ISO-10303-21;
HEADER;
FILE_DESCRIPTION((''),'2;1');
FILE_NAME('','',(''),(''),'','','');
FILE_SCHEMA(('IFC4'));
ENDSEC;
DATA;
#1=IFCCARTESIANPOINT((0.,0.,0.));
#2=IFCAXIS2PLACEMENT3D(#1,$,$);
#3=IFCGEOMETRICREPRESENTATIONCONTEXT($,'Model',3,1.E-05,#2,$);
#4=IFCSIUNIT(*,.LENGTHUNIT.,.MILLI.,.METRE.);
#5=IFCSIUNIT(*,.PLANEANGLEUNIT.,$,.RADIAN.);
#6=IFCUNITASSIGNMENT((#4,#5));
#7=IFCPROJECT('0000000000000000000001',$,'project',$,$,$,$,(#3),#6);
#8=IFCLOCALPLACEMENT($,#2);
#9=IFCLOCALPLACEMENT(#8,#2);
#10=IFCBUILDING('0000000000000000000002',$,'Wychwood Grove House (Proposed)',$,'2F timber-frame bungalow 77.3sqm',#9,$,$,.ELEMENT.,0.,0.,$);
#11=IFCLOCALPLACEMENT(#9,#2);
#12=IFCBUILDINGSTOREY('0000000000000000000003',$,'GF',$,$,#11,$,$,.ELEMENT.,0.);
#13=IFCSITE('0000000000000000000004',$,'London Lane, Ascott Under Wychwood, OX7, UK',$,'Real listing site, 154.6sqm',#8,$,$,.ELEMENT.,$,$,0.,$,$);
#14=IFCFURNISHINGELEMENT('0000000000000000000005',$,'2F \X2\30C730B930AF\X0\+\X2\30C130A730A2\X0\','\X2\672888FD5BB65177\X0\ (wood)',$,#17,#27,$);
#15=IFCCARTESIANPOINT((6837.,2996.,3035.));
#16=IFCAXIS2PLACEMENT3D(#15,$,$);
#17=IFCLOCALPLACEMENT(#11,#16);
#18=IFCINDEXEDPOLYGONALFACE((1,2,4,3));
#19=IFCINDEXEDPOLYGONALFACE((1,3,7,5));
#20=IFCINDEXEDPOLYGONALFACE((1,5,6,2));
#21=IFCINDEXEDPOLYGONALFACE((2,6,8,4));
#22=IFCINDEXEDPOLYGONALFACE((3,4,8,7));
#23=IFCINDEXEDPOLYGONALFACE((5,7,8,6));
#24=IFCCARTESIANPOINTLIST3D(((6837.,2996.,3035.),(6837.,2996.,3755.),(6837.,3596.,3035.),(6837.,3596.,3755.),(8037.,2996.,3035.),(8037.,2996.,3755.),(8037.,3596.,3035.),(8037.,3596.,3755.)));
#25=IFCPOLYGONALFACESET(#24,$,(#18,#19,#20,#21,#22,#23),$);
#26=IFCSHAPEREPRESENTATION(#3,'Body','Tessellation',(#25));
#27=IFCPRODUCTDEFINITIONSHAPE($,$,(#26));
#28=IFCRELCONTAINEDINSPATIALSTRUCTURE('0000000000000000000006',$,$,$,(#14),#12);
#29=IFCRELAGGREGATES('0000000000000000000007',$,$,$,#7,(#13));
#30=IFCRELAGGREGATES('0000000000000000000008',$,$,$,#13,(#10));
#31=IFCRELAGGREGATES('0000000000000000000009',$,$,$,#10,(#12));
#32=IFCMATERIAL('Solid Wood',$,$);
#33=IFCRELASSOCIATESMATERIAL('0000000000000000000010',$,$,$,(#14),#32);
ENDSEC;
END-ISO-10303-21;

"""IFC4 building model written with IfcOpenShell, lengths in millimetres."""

from ifc_helpers import new_model, si_unit, frame, frame_2d, origin, place, context, project, spatial, rectangle, extrude, material, element, save


model = new_model("IFC4")

# Units and contexts
model_context = context("Model", 3, precision=1e-05, world=origin())
ifc_project = project(units=[si_unit("LENGTHUNIT", "METRE", prefix="MILLI"), si_unit("PLANEANGLEUNIT", "RADIAN")], contexts=[model_context])

# Site, building, storey
site_placement = place(None, origin())
site = spatial("IfcSite", under=ifc_project, at=site_placement, Name="London Lane, Ascott Under Wychwood, OX7, UK", ObjectType="Real listing site, 154.6sqm", CompositionType="ELEMENT", RefElevation=0.0)
building_placement = place(site_placement, origin())
building = spatial("IfcBuilding", under=site, at=building_placement, Name="Wychwood Grove House (Proposed)", ObjectType="2F timber-frame bungalow 77.3sqm", CompositionType="ELEMENT", ElevationOfRefHeight=0.0, ElevationOfTerrain=0.0)
storey_placement = place(building_placement, origin())
storey = spatial("IfcBuildingStorey", under=building, at=storey_placement, Name="GF", CompositionType="ELEMENT", Elevation=0.0)

# Shared definitions
ifc_material_1 = material(Name="Solid Wood")

# Furnishing element
furnishing_1_placement = place(storey_placement, frame((6837.0, 2996.0, 3035.0)))
element("IfcFurnishingElement", 1, at=furnishing_1_placement, inside=storey, material=ifc_material_1, Name="2F デスク+チェア", Description="木製家具 (wood)", context=model_context, shape_type="SweptSolid", body=[
    extrude(rectangle(XDim=1200.0, YDim=600.0, at=frame_2d((600.0, 300.0))), frame((6837.0, 2996.0, 3035.0)), (0.0, 0.0, 1.0), 720.0),
])

save(model, "model.ifc")
